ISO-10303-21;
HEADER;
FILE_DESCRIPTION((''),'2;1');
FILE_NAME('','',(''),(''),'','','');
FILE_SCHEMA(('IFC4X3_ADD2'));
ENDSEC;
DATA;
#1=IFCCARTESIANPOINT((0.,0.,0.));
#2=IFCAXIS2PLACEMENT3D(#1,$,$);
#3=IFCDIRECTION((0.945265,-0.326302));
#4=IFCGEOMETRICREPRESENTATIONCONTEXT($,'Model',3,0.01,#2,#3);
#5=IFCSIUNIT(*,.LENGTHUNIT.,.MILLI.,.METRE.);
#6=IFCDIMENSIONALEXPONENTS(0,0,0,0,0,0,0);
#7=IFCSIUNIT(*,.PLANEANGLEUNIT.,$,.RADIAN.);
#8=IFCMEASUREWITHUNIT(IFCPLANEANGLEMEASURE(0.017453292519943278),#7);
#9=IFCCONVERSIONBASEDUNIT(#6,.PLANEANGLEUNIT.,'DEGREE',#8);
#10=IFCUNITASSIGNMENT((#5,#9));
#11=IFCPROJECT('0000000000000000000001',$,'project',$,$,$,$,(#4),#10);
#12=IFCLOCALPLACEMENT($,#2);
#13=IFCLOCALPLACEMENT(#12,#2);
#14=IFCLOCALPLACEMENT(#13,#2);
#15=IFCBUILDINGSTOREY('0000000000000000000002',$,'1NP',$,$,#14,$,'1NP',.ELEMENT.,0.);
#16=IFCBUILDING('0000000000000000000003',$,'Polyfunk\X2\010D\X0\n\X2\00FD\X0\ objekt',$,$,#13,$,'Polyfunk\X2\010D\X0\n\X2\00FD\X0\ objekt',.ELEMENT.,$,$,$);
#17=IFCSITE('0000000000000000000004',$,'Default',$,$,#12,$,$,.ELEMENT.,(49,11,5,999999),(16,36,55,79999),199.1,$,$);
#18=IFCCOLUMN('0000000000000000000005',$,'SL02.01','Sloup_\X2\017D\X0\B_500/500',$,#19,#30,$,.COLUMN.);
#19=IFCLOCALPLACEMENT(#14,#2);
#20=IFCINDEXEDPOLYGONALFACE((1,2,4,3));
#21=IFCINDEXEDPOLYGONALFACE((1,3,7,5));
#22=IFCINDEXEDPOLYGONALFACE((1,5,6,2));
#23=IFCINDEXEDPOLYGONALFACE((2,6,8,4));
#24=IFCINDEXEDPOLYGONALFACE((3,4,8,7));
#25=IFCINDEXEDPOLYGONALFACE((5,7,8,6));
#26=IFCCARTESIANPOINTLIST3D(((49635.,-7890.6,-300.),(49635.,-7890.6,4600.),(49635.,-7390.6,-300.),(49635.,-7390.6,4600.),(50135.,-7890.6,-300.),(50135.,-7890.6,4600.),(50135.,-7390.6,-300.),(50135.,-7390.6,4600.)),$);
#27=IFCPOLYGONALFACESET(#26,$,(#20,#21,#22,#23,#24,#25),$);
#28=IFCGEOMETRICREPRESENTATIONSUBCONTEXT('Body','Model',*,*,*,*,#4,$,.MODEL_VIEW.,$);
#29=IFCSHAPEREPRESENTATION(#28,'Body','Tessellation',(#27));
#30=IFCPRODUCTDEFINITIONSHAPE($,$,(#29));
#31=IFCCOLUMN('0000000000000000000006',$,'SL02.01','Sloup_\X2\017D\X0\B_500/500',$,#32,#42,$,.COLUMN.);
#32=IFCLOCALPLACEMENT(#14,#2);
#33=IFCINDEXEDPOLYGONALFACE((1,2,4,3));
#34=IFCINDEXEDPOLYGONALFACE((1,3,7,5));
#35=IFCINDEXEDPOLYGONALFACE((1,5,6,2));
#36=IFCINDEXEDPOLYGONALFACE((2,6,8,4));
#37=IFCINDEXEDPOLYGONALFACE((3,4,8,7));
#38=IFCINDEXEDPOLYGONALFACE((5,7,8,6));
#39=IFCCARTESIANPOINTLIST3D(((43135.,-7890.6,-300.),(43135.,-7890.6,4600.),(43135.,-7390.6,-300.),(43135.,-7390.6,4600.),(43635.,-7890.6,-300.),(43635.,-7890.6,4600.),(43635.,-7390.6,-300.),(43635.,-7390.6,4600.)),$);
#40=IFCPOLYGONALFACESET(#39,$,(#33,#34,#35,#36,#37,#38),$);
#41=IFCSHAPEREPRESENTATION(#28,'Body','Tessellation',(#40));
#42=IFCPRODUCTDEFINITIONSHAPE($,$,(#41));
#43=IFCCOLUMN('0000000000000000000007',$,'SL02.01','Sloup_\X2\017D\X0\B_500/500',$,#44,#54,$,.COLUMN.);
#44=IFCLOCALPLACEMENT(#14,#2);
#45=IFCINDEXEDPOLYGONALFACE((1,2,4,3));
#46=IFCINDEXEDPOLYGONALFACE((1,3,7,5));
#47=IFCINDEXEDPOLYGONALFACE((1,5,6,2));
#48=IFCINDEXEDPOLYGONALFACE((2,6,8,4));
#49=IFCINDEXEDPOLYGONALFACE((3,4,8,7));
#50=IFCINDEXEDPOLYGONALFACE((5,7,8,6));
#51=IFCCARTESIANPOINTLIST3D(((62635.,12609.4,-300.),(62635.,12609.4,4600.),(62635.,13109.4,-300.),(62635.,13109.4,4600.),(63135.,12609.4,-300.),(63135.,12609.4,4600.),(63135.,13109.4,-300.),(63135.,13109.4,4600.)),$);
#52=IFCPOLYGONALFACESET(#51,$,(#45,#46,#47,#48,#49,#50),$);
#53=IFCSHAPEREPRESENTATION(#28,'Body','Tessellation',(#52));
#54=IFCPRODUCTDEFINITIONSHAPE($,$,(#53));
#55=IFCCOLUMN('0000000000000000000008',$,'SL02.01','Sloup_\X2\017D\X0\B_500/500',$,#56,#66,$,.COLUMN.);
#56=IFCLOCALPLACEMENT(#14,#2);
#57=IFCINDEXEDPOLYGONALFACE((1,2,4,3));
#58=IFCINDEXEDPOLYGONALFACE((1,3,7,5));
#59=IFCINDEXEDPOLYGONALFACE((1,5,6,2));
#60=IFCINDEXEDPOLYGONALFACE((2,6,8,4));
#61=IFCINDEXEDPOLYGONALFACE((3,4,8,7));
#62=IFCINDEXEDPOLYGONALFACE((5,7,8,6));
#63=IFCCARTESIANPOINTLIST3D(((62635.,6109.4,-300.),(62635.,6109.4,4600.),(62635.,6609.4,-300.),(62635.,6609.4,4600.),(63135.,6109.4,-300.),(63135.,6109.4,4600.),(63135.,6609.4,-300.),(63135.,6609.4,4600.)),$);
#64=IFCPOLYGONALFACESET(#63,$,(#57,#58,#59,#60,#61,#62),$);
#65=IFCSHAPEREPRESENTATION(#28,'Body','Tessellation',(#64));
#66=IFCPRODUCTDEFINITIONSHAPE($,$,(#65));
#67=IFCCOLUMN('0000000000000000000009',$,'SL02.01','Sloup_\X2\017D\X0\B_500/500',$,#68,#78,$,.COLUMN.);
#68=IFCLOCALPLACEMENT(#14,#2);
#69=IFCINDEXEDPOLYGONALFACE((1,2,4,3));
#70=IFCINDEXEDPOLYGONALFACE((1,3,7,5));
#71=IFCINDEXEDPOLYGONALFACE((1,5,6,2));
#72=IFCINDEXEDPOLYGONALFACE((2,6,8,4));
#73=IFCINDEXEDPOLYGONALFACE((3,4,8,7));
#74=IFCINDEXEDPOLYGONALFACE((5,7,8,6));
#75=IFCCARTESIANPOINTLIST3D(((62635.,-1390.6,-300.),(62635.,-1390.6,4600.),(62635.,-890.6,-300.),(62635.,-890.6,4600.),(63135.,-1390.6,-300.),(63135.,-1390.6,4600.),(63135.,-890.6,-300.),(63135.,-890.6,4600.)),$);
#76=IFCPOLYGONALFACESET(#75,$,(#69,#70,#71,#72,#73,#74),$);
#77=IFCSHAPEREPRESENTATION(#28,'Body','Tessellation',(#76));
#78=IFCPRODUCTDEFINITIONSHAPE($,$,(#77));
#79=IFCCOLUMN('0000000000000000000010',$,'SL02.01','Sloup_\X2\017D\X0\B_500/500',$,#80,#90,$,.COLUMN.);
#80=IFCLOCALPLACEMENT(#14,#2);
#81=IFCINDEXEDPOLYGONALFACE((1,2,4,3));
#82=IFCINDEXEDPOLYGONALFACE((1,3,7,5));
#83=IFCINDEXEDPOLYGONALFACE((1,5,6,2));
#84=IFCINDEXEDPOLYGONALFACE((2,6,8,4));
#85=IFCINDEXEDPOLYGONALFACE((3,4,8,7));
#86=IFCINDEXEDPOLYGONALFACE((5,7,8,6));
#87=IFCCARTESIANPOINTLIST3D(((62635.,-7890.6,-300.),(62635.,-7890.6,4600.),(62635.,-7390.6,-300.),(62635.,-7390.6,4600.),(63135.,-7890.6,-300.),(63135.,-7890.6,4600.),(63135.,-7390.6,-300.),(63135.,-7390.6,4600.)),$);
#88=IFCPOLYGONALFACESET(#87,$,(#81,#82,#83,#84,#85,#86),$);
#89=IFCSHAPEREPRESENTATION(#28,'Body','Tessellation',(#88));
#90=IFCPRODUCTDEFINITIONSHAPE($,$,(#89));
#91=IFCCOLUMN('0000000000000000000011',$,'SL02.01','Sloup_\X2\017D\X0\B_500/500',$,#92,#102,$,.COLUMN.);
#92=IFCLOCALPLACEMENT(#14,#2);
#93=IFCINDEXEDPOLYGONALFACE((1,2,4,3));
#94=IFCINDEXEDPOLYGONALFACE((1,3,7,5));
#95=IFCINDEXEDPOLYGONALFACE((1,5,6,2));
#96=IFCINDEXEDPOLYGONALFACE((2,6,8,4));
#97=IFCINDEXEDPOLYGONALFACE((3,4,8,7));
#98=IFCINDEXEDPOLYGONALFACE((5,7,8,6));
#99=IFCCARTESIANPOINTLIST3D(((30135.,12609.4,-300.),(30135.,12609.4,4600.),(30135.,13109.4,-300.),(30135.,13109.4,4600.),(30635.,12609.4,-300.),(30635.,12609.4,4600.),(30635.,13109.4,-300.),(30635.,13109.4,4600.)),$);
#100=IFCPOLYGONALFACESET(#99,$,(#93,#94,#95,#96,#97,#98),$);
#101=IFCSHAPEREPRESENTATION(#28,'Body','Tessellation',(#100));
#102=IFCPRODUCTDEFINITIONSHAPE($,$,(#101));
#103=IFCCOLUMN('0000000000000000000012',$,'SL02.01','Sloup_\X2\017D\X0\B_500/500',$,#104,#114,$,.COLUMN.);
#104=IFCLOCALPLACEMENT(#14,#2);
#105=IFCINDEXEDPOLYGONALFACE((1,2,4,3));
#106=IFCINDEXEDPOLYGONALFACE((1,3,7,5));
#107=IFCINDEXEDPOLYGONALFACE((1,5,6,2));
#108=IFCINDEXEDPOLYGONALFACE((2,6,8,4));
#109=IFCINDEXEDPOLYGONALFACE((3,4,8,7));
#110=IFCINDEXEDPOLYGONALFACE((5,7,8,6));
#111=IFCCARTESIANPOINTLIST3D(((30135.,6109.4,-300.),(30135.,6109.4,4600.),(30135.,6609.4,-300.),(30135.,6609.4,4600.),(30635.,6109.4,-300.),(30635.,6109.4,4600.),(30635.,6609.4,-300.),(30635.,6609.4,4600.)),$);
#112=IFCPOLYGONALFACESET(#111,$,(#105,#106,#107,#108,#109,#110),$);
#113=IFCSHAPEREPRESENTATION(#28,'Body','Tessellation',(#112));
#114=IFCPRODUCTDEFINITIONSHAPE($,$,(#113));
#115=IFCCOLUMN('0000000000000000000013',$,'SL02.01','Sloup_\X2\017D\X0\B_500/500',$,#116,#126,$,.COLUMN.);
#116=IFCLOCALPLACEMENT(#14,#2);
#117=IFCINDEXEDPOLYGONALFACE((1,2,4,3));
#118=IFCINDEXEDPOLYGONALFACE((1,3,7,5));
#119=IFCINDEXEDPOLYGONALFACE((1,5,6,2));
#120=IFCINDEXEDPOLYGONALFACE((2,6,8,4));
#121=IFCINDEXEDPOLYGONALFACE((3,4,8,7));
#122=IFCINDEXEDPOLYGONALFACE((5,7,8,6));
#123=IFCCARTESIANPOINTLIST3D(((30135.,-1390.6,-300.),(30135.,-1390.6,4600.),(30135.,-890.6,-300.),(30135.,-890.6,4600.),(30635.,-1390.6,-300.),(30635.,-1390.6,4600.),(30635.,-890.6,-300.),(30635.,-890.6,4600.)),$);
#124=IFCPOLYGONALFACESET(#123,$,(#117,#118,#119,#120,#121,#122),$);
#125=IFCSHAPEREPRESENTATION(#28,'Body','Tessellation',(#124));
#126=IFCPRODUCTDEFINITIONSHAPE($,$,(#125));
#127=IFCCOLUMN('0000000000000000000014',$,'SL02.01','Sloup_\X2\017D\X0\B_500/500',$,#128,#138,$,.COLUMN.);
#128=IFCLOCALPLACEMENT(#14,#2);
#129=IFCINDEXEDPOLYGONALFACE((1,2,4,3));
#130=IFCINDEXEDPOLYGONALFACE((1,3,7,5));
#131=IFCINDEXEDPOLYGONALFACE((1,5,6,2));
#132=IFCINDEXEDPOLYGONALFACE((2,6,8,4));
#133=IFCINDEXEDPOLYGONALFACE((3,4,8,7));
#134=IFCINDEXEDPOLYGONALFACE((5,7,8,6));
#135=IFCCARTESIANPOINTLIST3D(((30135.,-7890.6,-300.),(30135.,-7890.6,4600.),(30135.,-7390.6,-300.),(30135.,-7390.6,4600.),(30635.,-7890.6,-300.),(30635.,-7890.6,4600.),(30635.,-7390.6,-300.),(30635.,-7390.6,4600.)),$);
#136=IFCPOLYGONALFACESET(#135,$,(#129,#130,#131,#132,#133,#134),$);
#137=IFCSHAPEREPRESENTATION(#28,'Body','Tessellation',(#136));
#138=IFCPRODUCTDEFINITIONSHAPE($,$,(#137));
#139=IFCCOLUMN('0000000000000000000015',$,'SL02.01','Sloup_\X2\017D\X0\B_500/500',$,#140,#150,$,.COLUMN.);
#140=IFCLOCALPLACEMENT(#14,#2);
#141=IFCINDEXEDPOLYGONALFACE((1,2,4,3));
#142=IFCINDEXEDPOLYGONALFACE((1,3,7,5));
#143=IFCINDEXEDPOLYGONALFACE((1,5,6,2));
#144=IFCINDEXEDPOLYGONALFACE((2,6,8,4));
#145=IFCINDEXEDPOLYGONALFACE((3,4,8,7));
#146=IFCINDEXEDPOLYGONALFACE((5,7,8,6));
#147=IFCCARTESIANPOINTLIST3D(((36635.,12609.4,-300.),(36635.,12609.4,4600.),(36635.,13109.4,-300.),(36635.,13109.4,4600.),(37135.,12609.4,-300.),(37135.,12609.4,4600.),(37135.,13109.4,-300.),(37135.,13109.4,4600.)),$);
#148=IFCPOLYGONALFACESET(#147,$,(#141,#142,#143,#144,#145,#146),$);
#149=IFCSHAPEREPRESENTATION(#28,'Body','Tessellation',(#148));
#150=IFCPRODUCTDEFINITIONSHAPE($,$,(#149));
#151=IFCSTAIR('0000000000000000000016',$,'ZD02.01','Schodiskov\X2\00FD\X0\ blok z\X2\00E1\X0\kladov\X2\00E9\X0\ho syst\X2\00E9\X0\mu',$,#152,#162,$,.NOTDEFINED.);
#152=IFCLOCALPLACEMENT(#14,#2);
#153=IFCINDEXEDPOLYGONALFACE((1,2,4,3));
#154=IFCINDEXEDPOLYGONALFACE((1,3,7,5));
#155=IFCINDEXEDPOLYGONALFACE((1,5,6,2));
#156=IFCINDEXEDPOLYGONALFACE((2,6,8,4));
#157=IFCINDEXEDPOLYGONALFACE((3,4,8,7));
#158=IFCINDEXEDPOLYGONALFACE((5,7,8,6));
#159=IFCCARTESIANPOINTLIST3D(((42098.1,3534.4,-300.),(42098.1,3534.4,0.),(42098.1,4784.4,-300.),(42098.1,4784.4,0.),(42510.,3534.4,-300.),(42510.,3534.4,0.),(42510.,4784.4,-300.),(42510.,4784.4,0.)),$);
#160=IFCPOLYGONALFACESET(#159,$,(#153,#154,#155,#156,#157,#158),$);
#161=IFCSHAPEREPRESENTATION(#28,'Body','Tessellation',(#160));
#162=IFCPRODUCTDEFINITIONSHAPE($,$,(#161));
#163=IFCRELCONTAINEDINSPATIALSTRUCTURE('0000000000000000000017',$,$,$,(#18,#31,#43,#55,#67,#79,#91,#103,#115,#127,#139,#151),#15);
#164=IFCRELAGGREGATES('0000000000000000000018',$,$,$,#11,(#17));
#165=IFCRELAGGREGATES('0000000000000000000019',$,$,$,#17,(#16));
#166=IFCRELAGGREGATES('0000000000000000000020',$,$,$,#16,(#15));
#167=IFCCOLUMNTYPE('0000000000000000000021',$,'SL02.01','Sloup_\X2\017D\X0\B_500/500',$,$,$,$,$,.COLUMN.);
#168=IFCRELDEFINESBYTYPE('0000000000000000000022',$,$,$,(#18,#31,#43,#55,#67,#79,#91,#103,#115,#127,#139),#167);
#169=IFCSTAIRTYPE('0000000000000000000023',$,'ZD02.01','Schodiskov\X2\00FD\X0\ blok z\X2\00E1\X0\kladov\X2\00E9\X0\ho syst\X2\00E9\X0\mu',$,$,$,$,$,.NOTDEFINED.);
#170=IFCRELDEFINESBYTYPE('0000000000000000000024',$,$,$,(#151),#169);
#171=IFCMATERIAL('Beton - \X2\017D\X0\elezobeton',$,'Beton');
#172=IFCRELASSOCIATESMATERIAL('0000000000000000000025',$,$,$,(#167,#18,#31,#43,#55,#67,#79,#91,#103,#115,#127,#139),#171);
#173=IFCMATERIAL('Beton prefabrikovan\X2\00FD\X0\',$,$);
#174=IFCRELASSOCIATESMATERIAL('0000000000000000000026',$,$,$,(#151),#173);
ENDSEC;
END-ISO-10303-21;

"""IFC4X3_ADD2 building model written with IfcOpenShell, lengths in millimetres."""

from ifc_helpers import new_model, entity, si_unit, converted_unit, direction, frame, frame_2d, origin, origin_2d_with_axis, place, context, subcontext, project, spatial, rectangle, extrude, source, transform, mapped, material, material_profile, profile_set, profile_usage, type_object, element, save


model = new_model("IFC4X3_ADD2")

# Units and contexts
model_context = context("Model", 3, precision=0.01, world=origin(), true_north=direction((0.945265, -0.326302)))
body_context = subcontext(model_context, "Body", "Model", "MODEL_VIEW")
ifc_project = project(units=[si_unit("LENGTHUNIT", "METRE", prefix="MILLI"), converted_unit("PLANEANGLEUNIT", "DEGREE", entity("IfcPlaneAngleMeasure", 0.017453292519943278), si_unit("PLANEANGLEUNIT", "RADIAN"), dimensions=[0, 0, 0, 0, 0, 0, 0])], contexts=[model_context])

# Site, building, storey
site_placement = place(None, origin())
site = spatial("IfcSite", under=ifc_project, at=site_placement, Name="Default", CompositionType="ELEMENT", RefLatitude=(49, 11, 5, 999999), RefLongitude=(16, 36, 55, 79999), RefElevation=199.1)
building_placement = place(site_placement, origin())
building = spatial("IfcBuilding", under=site, at=building_placement, Name="Polyfunkčný objekt", LongName="Polyfunkčný objekt", CompositionType="ELEMENT")
storey_placement = place(building_placement, origin())
storey = spatial("IfcBuildingStorey", under=building, at=storey_placement, Name="1NP", LongName="1NP", CompositionType="ELEMENT", Elevation=0.0)

# Columns
ifc_material_1 = material(Name="Beton - Železobeton", Category="Beton")
ifc_material_profile = material_profile(ifc_material_1, rectangle(XDim=500.0, YDim=500.0, at=frame_2d((0.0, 0.0), x_axis=(1.0, 0.0))), Name="Sloup_ŽB_500/500")
ifc_profile_set = profile_set([ifc_material_profile], Name="Sloup_ŽB_500/500")
ifc_profile_usage = profile_usage(ifc_profile_set)
column_type = type_object("IfcColumnType", Name="SL02.01", Description="Sloup_ŽB_500/500", PredefinedType="COLUMN", material=ifc_profile_set)
shared_shape_1 = source(origin(), body_context, "Body", "SweptSolid", [
    extrude(rectangle(XDim=500.0, YDim=500.0, at=frame_2d((0.0, 0.0), x_axis=(1.0, 0.0))), frame((49885.0, -7640.6, -300.0)), (0.0, 0.0, 1.0), 4900.0),
])
column_1_placement = place(storey_placement, origin())
element("IfcColumn", 1, at=column_1_placement, inside=storey, type_object=column_type, material=ifc_profile_usage, Name="SL02.01", Description="Sloup_ŽB_500/500", PredefinedType="COLUMN", context=body_context, shape_type="MappedRepresentation", body=[
    mapped(shared_shape_1, transform((0.0, 0.0, 0.0), scale=1.0)),
])
shared_shape_2 = source(origin(), body_context, "Body", "SweptSolid", [
    extrude(rectangle(XDim=500.0, YDim=500.0, at=origin_2d_with_axis()), frame((43385.0, -7640.6, -300.0)), (0.0, 0.0, 1.0), 4900.0),
])
column_2_placement = place(storey_placement, origin())
element("IfcColumn", 2, at=column_2_placement, inside=storey, type_object=column_type, material=ifc_profile_usage, Name="SL02.01", Description="Sloup_ŽB_500/500", PredefinedType="COLUMN", context=body_context, shape_type="MappedRepresentation", body=[
    mapped(shared_shape_2, transform((0.0, 0.0, 0.0), scale=1.0)),
])
shared_shape_3 = source(origin(), body_context, "Body", "SweptSolid", [
    extrude(rectangle(XDim=500.0, YDim=500.0, at=origin_2d_with_axis()), frame((62885.0, 12859.4, -300.0), z_axis=(0.0, 0.0, 1.0), x_axis=(-1.0, 0.0, 0.0)), (0.0, 0.0, 1.0), 4900.0),
])
column_3_placement = place(storey_placement, origin())
element("IfcColumn", 3, at=column_3_placement, inside=storey, type_object=column_type, material=ifc_profile_usage, Name="SL02.01", Description="Sloup_ŽB_500/500", PredefinedType="COLUMN", context=body_context, shape_type="MappedRepresentation", body=[
    mapped(shared_shape_3, transform((0.0, 0.0, 0.0), scale=1.0)),
])
shared_shape_4 = source(origin(), body_context, "Body", "SweptSolid", [
    extrude(rectangle(XDim=500.0, YDim=500.0, at=origin_2d_with_axis()), frame((62885.0, 6359.4, -300.0), z_axis=(0.0, 0.0, 1.0), x_axis=(0.0, -1.0, 0.0)), (0.0, 0.0, 1.0), 4900.0),
])
column_4_placement = place(storey_placement, origin())
element("IfcColumn", 4, at=column_4_placement, inside=storey, type_object=column_type, material=ifc_profile_usage, Name="SL02.01", Description="Sloup_ŽB_500/500", PredefinedType="COLUMN", context=body_context, shape_type="MappedRepresentation", body=[
    mapped(shared_shape_4, transform((0.0, 0.0, 0.0), scale=1.0)),
])
shared_shape_5 = source(origin(), body_context, "Body", "SweptSolid", [
    extrude(rectangle(XDim=500.0, YDim=500.0, at=origin_2d_with_axis()), frame((62885.0, -1140.6, -300.0), z_axis=(0.0, 0.0, 1.0), x_axis=(0.0, -1.0, 0.0)), (0.0, 0.0, 1.0), 4900.0),
])
column_5_placement = place(storey_placement, origin())
element("IfcColumn", 5, at=column_5_placement, inside=storey, type_object=column_type, material=ifc_profile_usage, Name="SL02.01", Description="Sloup_ŽB_500/500", PredefinedType="COLUMN", context=body_context, shape_type="MappedRepresentation", body=[
    mapped(shared_shape_5, transform((0.0, 0.0, 0.0), scale=1.0)),
])
shared_shape_6 = source(origin(), body_context, "Body", "SweptSolid", [
    extrude(rectangle(XDim=500.0, YDim=500.0, at=origin_2d_with_axis()), frame((62885.0, -7640.6, -300.0), z_axis=(0.0, 0.0, 1.0), x_axis=(-1.0, 0.0, 0.0)), (0.0, 0.0, 1.0), 4900.0),
])
column_6_placement = place(storey_placement, origin())
element("IfcColumn", 6, at=column_6_placement, inside=storey, type_object=column_type, material=ifc_profile_usage, Name="SL02.01", Description="Sloup_ŽB_500/500", PredefinedType="COLUMN", context=body_context, shape_type="MappedRepresentation", body=[
    mapped(shared_shape_6, transform((0.0, 0.0, 0.0), scale=1.0)),
])
shared_shape_7 = source(origin(), body_context, "Body", "SweptSolid", [
    extrude(rectangle(XDim=500.0, YDim=500.0, at=origin_2d_with_axis()), frame((30385.0, 12859.4, -300.0), z_axis=(0.0, 0.0, 1.0), x_axis=(-1.0, 0.0, 0.0)), (0.0, 0.0, 1.0), 4900.0),
])
column_7_placement = place(storey_placement, origin())
element("IfcColumn", 7, at=column_7_placement, inside=storey, type_object=column_type, material=ifc_profile_usage, Name="SL02.01", Description="Sloup_ŽB_500/500", PredefinedType="COLUMN", context=body_context, shape_type="MappedRepresentation", body=[
    mapped(shared_shape_7, transform((0.0, 0.0, 0.0), scale=1.0)),
])
shared_shape_8 = source(origin(), body_context, "Body", "SweptSolid", [
    extrude(rectangle(XDim=500.0, YDim=500.0, at=frame_2d((0.0, 0.0), x_axis=(1.0, 0.0))), frame((30385.0, 6359.4, -300.0), z_axis=(0.0, 0.0, 1.0), x_axis=(0.0, -1.0, 0.0)), (0.0, 0.0, 1.0), 4900.0),
])
column_8_placement = place(storey_placement, origin())
element("IfcColumn", 8, at=column_8_placement, inside=storey, type_object=column_type, material=ifc_profile_usage, Name="SL02.01", Description="Sloup_ŽB_500/500", PredefinedType="COLUMN", context=body_context, shape_type="MappedRepresentation", body=[
    mapped(shared_shape_8, transform((0.0, 0.0, 0.0), scale=1.0)),
])
shared_shape_9 = source(origin(), body_context, "Body", "SweptSolid", [
    extrude(rectangle(XDim=500.0, YDim=500.0, at=origin_2d_with_axis()), frame((30385.0, -1140.6, -300.0), z_axis=(0.0, 0.0, 1.0), x_axis=(0.0, -1.0, 0.0)), (0.0, 0.0, 1.0), 4900.0),
])
column_9_placement = place(storey_placement, origin())
element("IfcColumn", 9, at=column_9_placement, inside=storey, type_object=column_type, material=ifc_profile_usage, Name="SL02.01", Description="Sloup_ŽB_500/500", PredefinedType="COLUMN", context=body_context, shape_type="MappedRepresentation", body=[
    mapped(shared_shape_9, transform((0.0, 0.0, 0.0), scale=1.0)),
])
shared_shape_10 = source(origin(), body_context, "Body", "SweptSolid", [
    extrude(rectangle(XDim=500.0, YDim=500.0, at=frame_2d((0.0, 0.0), x_axis=(1.0, 0.0))), frame((30385.0, -7640.6, -300.0), z_axis=(0.0, 0.0, 1.0), x_axis=(-1.0, 0.0, 0.0)), (0.0, 0.0, 1.0), 4900.0),
])
column_10_placement = place(storey_placement, origin())
element("IfcColumn", 10, at=column_10_placement, inside=storey, type_object=column_type, material=ifc_profile_usage, Name="SL02.01", Description="Sloup_ŽB_500/500", PredefinedType="COLUMN", context=body_context, shape_type="MappedRepresentation", body=[
    mapped(shared_shape_10, transform((0.0, 0.0, 0.0), scale=1.0)),
])
shared_shape_11 = source(origin(), body_context, "Body", "SweptSolid", [
    extrude(rectangle(XDim=500.0, YDim=500.0, at=frame_2d((-83.3, 0.0), x_axis=(1.0, 0.0))), frame((36885.0, 12776.1, -300.0), z_axis=(0.0, 0.0, 1.0), x_axis=(0.0, -1.0, 0.0)), (0.0, 0.0, 1.0), 4900.0),
])
column_11_placement = place(storey_placement, origin())
element("IfcColumn", 11, at=column_11_placement, inside=storey, type_object=column_type, material=ifc_profile_usage, Name="SL02.01", Description="Sloup_ŽB_500/500", PredefinedType="COLUMN", context=body_context, shape_type="MappedRepresentation", body=[
    mapped(shared_shape_11, transform((0.0, 0.0, 0.0), scale=1.0)),
])

# Stair
ifc_material_2 = material(Name="Beton prefabrikovaný")
stair_type = type_object("IfcStairType", Name="ZD02.01", Description="Schodiskový blok základového systému", PredefinedType="NOTDEFINED")
stair_placement = place(storey_placement, origin())
element("IfcStair", 12, at=stair_placement, inside=storey, type_object=stair_type, material=ifc_material_2, Name="ZD02.01", Description="Schodiskový blok základového systému", PredefinedType="NOTDEFINED", context=body_context, shape_type="SweptSolid", body=[
    extrude(rectangle(XDim=1250.0, YDim=411.8, at=frame_2d((0.0, 0.0), x_axis=(1.0, 0.0))), frame((42304.0, 4159.4, -300.0), z_axis=(0.0, 0.0, 1.0), x_axis=(0.0, -1.0, 0.0)), (0.0, 0.0, 1.0), 300.0),
])

save(model, "model.ifc")
